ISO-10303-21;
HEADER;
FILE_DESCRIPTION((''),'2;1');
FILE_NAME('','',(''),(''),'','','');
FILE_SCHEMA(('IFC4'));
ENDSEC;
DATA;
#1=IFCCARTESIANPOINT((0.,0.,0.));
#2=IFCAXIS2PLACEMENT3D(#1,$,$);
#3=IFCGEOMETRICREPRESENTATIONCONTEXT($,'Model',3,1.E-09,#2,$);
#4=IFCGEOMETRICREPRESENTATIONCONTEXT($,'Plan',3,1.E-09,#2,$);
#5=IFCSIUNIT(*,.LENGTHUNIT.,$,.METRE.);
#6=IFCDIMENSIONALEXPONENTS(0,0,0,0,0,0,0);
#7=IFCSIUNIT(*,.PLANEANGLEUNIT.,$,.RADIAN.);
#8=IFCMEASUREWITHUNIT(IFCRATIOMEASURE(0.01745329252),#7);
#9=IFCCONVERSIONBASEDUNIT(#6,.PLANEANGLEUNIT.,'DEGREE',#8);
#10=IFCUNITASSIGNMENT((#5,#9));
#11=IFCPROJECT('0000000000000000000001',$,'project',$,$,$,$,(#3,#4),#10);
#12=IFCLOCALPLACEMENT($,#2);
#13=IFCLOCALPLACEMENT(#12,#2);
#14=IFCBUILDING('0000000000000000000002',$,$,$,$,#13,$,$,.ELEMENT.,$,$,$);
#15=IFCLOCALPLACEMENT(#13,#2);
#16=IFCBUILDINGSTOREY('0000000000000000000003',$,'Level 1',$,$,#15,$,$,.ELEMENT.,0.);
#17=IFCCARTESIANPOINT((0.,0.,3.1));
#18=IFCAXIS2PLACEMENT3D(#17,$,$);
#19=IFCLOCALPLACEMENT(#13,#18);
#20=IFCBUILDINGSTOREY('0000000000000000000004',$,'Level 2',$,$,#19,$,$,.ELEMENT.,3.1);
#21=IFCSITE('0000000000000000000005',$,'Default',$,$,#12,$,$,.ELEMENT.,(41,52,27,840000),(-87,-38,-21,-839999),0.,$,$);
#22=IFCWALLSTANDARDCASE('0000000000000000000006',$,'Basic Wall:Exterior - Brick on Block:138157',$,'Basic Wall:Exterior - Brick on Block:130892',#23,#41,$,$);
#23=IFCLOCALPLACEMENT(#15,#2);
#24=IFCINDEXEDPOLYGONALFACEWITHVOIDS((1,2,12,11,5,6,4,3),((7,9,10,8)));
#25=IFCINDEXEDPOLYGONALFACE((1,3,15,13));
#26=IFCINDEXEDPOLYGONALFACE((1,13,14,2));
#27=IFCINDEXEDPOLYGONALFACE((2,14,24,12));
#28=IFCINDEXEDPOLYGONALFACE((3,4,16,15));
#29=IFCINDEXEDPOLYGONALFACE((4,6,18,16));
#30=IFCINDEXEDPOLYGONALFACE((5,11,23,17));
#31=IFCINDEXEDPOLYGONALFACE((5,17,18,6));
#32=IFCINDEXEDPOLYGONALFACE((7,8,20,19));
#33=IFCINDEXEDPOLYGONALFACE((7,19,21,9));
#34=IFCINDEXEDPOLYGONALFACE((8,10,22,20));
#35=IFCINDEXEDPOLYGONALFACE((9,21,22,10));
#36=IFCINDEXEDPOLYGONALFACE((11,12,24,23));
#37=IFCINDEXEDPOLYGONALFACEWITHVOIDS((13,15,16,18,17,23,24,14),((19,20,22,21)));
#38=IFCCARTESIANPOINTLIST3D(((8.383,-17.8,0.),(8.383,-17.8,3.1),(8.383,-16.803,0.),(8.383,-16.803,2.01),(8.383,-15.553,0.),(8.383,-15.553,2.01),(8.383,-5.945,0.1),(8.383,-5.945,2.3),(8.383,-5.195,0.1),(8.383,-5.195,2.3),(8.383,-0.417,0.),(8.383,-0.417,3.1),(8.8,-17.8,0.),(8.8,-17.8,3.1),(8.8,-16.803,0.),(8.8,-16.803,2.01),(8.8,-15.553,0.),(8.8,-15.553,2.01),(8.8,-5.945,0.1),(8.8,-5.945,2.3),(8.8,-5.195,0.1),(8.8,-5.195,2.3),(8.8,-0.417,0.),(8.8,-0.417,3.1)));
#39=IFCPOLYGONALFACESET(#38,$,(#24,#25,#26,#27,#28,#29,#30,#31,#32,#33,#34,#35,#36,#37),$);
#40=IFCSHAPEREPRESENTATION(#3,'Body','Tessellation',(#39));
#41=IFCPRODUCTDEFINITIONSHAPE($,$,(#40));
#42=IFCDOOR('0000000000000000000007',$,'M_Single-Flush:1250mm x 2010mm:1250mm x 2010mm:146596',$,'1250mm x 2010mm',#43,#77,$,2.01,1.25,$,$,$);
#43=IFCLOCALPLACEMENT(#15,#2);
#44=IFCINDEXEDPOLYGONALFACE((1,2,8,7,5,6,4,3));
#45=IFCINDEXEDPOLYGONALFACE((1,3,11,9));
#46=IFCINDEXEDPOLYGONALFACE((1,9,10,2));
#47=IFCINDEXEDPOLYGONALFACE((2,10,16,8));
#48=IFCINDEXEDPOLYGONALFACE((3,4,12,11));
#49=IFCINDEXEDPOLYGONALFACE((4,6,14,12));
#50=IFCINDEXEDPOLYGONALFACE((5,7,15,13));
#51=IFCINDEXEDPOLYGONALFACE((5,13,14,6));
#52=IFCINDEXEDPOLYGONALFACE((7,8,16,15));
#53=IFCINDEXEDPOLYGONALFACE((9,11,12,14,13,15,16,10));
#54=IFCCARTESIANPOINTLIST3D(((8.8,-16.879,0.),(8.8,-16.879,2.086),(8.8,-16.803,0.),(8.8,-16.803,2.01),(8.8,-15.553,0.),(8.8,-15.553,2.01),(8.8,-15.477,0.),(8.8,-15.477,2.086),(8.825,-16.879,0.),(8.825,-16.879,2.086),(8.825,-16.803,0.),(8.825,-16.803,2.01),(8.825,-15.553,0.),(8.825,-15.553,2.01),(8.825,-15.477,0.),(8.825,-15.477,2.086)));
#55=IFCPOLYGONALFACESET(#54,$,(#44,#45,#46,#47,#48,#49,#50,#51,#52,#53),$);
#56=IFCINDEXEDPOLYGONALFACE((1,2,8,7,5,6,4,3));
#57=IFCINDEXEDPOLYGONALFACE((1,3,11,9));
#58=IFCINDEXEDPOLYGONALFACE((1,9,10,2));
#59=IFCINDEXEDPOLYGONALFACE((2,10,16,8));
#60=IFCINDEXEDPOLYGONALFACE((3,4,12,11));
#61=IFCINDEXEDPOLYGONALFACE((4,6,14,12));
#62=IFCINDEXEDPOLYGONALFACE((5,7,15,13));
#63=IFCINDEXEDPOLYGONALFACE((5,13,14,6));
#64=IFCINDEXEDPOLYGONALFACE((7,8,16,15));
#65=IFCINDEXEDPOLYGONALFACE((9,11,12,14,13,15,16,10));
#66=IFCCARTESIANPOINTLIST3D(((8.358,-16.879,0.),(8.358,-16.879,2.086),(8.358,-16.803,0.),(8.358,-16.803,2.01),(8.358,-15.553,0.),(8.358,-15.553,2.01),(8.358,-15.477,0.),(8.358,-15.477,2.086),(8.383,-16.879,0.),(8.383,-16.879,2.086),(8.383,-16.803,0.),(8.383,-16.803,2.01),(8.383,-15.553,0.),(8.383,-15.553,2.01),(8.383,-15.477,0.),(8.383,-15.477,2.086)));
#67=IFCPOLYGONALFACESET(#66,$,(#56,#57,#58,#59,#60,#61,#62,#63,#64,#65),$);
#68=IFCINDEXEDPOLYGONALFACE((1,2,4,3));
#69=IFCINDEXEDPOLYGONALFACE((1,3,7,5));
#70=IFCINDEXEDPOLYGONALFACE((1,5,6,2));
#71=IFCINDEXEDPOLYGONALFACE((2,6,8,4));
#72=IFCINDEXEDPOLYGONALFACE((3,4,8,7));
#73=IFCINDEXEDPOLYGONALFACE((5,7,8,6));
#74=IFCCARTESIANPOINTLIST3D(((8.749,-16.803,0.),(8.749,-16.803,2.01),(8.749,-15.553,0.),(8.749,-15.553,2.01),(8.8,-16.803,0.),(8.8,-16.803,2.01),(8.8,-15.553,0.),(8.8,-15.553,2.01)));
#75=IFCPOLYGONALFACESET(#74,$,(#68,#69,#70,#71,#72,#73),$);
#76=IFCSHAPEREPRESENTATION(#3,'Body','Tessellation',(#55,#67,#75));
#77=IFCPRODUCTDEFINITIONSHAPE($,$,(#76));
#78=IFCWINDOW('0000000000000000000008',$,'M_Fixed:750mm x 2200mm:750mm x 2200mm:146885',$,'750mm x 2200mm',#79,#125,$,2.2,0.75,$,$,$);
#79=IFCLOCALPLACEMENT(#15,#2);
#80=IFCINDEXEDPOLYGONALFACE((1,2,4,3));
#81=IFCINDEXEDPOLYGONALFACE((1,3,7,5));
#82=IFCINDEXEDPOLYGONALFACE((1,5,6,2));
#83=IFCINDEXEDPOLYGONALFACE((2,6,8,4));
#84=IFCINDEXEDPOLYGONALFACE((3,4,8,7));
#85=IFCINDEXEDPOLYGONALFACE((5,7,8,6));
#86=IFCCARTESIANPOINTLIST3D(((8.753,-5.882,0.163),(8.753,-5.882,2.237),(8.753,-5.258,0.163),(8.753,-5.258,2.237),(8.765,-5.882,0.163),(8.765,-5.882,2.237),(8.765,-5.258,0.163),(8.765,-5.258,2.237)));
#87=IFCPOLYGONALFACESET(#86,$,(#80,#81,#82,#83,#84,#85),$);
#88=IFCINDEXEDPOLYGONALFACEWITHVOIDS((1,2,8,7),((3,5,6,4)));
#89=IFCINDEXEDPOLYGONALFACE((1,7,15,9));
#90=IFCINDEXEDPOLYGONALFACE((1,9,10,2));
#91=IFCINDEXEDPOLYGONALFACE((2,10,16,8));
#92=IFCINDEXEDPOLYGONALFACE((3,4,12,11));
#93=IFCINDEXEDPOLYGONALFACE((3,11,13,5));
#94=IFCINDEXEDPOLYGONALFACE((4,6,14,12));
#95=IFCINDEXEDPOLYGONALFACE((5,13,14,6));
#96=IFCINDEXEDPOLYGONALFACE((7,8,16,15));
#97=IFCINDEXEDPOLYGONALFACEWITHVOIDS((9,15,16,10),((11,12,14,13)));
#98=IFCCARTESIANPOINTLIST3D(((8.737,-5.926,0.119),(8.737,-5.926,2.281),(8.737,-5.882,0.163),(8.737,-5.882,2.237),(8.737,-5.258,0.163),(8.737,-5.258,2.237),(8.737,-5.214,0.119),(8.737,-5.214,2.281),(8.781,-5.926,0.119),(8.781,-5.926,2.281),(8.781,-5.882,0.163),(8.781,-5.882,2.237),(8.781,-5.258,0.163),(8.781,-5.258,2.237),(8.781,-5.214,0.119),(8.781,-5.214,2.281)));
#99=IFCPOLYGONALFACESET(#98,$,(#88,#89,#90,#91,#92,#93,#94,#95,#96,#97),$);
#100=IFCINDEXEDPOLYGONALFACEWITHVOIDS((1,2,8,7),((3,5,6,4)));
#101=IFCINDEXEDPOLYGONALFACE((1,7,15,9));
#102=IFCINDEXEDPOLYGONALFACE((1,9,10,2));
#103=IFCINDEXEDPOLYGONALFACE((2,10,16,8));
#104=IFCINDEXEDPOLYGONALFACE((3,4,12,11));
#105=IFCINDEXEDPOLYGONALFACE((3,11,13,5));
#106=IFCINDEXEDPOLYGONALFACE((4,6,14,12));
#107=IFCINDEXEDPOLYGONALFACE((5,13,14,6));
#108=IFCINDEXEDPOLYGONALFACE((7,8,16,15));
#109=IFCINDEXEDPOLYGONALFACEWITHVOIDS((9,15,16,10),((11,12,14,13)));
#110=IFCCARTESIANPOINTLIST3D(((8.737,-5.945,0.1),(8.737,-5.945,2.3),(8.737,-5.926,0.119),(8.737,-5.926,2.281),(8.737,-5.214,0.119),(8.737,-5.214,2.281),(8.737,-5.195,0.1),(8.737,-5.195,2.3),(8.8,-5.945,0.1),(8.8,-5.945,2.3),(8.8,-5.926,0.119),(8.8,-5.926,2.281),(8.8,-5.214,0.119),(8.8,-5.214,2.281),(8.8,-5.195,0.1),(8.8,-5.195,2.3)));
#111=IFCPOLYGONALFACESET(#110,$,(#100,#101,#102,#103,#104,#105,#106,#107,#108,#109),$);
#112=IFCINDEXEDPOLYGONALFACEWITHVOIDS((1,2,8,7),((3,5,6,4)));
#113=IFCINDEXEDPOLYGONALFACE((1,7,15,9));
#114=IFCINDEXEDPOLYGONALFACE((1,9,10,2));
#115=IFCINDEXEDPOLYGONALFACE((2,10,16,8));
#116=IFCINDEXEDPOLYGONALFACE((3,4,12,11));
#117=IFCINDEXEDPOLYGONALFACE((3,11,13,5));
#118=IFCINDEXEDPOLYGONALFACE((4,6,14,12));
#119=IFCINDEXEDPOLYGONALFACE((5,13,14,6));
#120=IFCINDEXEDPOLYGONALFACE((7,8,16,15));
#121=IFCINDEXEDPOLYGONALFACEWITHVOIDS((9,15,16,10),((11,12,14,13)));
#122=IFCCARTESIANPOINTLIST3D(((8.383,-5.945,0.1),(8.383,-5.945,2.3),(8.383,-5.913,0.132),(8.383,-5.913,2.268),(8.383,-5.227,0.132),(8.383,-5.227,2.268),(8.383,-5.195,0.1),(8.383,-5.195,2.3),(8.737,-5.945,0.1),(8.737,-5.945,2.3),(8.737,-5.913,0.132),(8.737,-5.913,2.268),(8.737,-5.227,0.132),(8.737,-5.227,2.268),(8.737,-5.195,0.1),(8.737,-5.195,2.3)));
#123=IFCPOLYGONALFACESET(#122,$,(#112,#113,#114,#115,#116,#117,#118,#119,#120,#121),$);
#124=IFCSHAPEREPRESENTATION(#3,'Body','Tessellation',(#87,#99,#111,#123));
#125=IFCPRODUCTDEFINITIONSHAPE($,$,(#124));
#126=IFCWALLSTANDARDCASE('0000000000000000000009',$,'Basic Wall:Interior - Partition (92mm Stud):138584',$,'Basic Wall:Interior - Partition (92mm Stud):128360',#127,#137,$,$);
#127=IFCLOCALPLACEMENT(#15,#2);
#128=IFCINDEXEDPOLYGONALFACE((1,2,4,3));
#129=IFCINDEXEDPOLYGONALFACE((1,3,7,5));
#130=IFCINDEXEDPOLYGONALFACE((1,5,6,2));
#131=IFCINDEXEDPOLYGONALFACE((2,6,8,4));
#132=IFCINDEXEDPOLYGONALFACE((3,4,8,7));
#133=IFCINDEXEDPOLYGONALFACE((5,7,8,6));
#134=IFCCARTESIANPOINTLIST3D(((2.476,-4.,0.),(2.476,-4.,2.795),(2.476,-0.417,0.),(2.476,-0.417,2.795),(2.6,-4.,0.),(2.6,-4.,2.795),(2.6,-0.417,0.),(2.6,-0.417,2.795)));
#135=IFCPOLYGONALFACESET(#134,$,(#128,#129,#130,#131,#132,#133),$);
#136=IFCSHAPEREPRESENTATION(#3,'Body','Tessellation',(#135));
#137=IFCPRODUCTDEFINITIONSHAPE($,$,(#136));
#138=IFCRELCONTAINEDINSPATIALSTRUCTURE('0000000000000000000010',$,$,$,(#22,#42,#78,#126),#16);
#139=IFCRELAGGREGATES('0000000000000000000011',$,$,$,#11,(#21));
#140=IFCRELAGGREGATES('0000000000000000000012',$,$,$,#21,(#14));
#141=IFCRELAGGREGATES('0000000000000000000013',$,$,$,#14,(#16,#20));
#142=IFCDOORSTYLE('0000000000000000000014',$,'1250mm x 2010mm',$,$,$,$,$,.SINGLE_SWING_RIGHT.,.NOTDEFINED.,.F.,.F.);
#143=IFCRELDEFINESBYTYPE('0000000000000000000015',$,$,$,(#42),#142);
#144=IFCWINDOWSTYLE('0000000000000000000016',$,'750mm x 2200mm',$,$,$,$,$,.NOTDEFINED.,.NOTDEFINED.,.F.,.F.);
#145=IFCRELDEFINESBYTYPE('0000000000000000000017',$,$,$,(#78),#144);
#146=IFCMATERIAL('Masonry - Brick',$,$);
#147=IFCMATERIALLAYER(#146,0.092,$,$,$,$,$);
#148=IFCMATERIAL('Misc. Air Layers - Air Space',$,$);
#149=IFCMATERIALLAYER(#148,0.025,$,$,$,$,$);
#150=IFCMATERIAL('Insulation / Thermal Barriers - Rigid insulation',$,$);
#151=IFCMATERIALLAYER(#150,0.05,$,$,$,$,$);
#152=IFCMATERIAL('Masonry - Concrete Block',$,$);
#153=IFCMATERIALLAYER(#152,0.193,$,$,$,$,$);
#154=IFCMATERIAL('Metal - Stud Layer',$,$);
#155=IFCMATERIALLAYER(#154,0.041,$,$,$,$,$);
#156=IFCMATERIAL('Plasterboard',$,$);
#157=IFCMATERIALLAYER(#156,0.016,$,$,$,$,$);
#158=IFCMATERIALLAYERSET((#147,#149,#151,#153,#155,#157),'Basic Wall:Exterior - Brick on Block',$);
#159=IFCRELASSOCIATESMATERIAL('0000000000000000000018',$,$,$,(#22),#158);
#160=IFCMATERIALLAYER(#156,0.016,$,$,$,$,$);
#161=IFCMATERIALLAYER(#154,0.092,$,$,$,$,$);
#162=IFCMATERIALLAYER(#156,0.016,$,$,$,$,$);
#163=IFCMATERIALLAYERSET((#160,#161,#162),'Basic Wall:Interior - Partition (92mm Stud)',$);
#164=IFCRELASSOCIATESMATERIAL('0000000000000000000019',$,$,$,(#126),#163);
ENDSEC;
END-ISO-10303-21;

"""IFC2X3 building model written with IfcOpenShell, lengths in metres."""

from ifc_helpers import new_model, entity, si_unit, converted_unit, frame, frame_2d, origin, origin_2d_with_axis, place, context, project, spatial, polyline, rectangle, outline, extrude, source, transform, mapped, material, layer, layer_set, layer_usage, type_object, type_shapes, element, fill, save


model = new_model("IFC2X3")

# Units and contexts
model_context = context("Model", 3, precision=1e-09, world=origin())
plan_context = context("Plan", 3, precision=1e-09, world=origin())
ifc_project = project(units=[si_unit("LENGTHUNIT", "METRE"), converted_unit("PLANEANGLEUNIT", "DEGREE", entity("IfcRatioMeasure", 0.01745329252), si_unit("PLANEANGLEUNIT", "RADIAN"), dimensions=[0, 0, 0, 0, 0, 0, 0])], contexts=[model_context, plan_context])

# Site, building, storey
site_placement = place(None, origin())
site = spatial("IfcSite", under=ifc_project, at=site_placement, Name="Default", CompositionType="ELEMENT", RefLatitude=(41, 52, 27, 840000), RefLongitude=(-87, -38, -21, -839999), RefElevation=0.0)
building_placement = place(site_placement, origin())
building = spatial("IfcBuilding", under=site, at=building_placement, CompositionType="ELEMENT")
storey_1_placement = place(building_placement, origin())
storey_1 = spatial("IfcBuildingStorey", under=building, at=storey_1_placement, Name="Level 1", CompositionType="ELEMENT", Elevation=0.0)

# Shared definitions
ifc_material_1 = material(Name="Masonry - Brick")
ifc_layer_1 = layer(ifc_material_1, 0.092)
ifc_material_2 = material(Name="Misc. Air Layers - Air Space")
ifc_layer_2 = layer(ifc_material_2, 0.025)
ifc_material_3 = material(Name="Insulation / Thermal Barriers - Rigid insulation")
ifc_layer_3 = layer(ifc_material_3, 0.05)
ifc_material_4 = material(Name="Masonry - Concrete Block")
ifc_layer_4 = layer(ifc_material_4, 0.193)
ifc_material_5 = material(Name="Metal - Stud Layer")
ifc_layer_5 = layer(ifc_material_5, 0.041)
ifc_material_6 = material(Name="Plasterboard")
ifc_layer_6 = layer(ifc_material_6, 0.016)
ifc_layer_set_1 = layer_set([ifc_layer_1, ifc_layer_2, ifc_layer_3, ifc_layer_4, ifc_layer_5, ifc_layer_6], Name="Basic Wall:Exterior - Brick on Block")

# Wall, openings, door, window
ifc_layer_usage_1 = layer_usage(ifc_layer_set_1, "AXIS2", "NEGATIVE", 0.2085)
wall_1_placement = place(storey_1_placement, frame((8.5915, -0.417, 0.0), z_axis=(0.0, 0.0, 1.0), x_axis=(0.0, -1.0, 0.0)))
wall_1 = element("IfcWallStandardCase", 1, at=wall_1_placement, inside=storey_1, material=ifc_layer_usage_1, Name="Basic Wall:Exterior - Brick on Block:138157", ObjectType="Basic Wall:Exterior - Brick on Block:130892", context=model_context, shape_type="SweptSolid", body=[
    extrude(rectangle(XDim=17.383, YDim=0.417, at=frame_2d((8.6915, 0.0), x_axis=(-1.0, 0.0))), origin(), (0.0, 0.0, 1.0), 3.1),
])
opening_1_placement = place(wall_1_placement, frame((15.136, -0.2085, 0.0)))
opening_1 = element("IfcOpeningElement", 2, at=opening_1_placement, cuts=wall_1, ObjectType="Opening", context=model_context, shape_type="SweptSolid", body=[
    extrude(rectangle(XDim=1.25, YDim=2.01, at=frame_2d((1.005, 0.625), x_axis=(0.0, 1.0))), frame((0.0, 0.0, 0.0), z_axis=(0.0, 1.0, 0.0), x_axis=(0.0, 0.0, 1.0)), (0.0, 0.0, 1.0), 0.417),
])
opening_2_placement = place(wall_1_placement, frame((4.778, -0.2085, 0.1)))
opening_2 = element("IfcOpeningElement", 3, at=opening_2_placement, cuts=wall_1, ObjectType="Opening", context=model_context, shape_type="SweptSolid", body=[
    extrude(rectangle(XDim=2.2, YDim=0.75, at=frame_2d((1.1, 0.375), x_axis=(1.0, 0.0))), frame((0.0, 0.0, 0.0), z_axis=(0.0, 1.0, 0.0), x_axis=(0.0, 0.0, 1.0)), (0.0, 0.0, 1.0), 0.417),
])
door_style_1 = type_object("IfcDoorStyle", Name="1250mm x 2010mm", ConstructionType="NOTDEFINED", OperationType="SINGLE_SWING_RIGHT", ParameterTakesPrecedence=False, Sizeable=False)
shared_shape_1 = source(origin(), model_context, "Body", "SweptSolid", [
    extrude(outline(polyline([(-0.701, -1.062), (0.701, -1.062), (0.701, 1.024), (0.625, 1.024), (0.625, -0.986), (-0.625, -0.986), (-0.625, 1.024), (-0.701, 1.024), (-0.701, -1.062)])), frame((0.625, 0.417, 1.024), z_axis=(0.0, 1.0, 0.0), x_axis=(1.0, 0.0, 0.0)), (0.0, 0.0, 1.0), 0.025),
    extrude(outline(polyline([(-1.062, -0.701), (1.024, -0.701), (1.024, -0.625), (-0.986, -0.625), (-0.986, 0.625), (1.024, 0.625), (1.024, 0.701), (-1.062, 0.701), (-1.062, -0.701)])), frame((0.625, -0.025, 1.024), z_axis=(0.0, 1.0, 0.0), x_axis=(0.0, 0.0, -1.0)), (0.0, 0.0, 1.0), 0.025),
    extrude(rectangle(XDim=0.051, YDim=1.25, at=origin_2d_with_axis()), frame((0.625, 0.3915, 0.0), z_axis=(0.0, 0.0, 1.0), x_axis=(0.0, 1.0, 0.0)), (0.0, 0.0, 1.0), 2.01),
])
type_shapes(door_style_1, [shared_shape_1])
door_1_placement = place(opening_1_placement, origin())
door_1 = element("IfcDoor", 4, at=door_1_placement, inside=storey_1, type_object=door_style_1, Name="M_Single-Flush:1250mm x 2010mm:1250mm x 2010mm:146596", ObjectType="1250mm x 2010mm", OverallHeight=2.01, OverallWidth=1.25, context=model_context, shape_type="MappedRepresentation", body=[
    mapped(shared_shape_1, transform((0.0, 0.0, 0.0), scale=1.0)),
])
fill(opening_1, door_1)
window_style_1 = type_object("IfcWindowStyle", Name="750mm x 2200mm", ConstructionType="NOTDEFINED", OperationType="NOTDEFINED", ParameterTakesPrecedence=False, Sizeable=False)
shared_shape_2 = source(origin(), model_context, "Body", "SweptSolid", [
    extrude(rectangle(XDim=0.012, YDim=0.624, at=origin_2d_with_axis()), frame((0.375, 0.376, 0.063), z_axis=(0.0, 0.0, 1.0), x_axis=(0.0, -1.0, 0.0)), (0.0, 0.0, 1.0), 2.074),
    extrude(outline(polyline([(-0.356, -1.081), (0.356, -1.081), (0.356, 1.081), (-0.356, 1.081), (-0.356, -1.081)]), holes=[polyline([(-0.312, -1.037), (-0.312, 1.037), (0.312, 1.037), (0.312, -1.037), (-0.312, -1.037)])]), frame((0.375, 0.354, 1.1), z_axis=(0.0, 1.0, 0.0), x_axis=(1.0, 0.0, 0.0)), (0.0, 0.0, 1.0), 0.044),
    extrude(outline(polyline([(-0.375, -1.1), (0.375, -1.1), (0.375, 1.1), (-0.375, 1.1), (-0.375, -1.1)]), holes=[polyline([(-0.356, -1.081), (-0.356, 1.081), (0.356, 1.081), (0.356, -1.081), (-0.356, -1.081)])]), frame((0.375, 0.354, 1.1), z_axis=(0.0, 1.0, 0.0), x_axis=(1.0, 0.0, 0.0)), (0.0, 0.0, 1.0), 0.063),
    extrude(outline(polyline([(-0.375, -1.1), (0.375, -1.1), (0.375, 1.1), (-0.375, 1.1), (-0.375, -1.1)]), holes=[polyline([(-0.343, -1.068), (-0.343, 1.068), (0.343, 1.068), (0.343, -1.068), (-0.343, -1.068)])]), frame((0.375, 0.0, 1.1), z_axis=(0.0, 1.0, 0.0), x_axis=(1.0, 0.0, 0.0)), (0.0, 0.0, 1.0), 0.354),
])
type_shapes(window_style_1, [shared_shape_2])
window_1_placement = place(opening_2_placement, origin())
window_1 = element("IfcWindow", 5, at=window_1_placement, inside=storey_1, type_object=window_style_1, Name="M_Fixed:750mm x 2200mm:750mm x 2200mm:146885", ObjectType="750mm x 2200mm", OverallHeight=2.2, OverallWidth=0.75, context=model_context, shape_type="MappedRepresentation", body=[
    mapped(shared_shape_2, transform((0.0, 0.0, 0.0), scale=1.0)),
])
fill(opening_2, window_1)

# Wall
ifc_layer_7 = layer(ifc_material_6, 0.016)
ifc_layer_8 = layer(ifc_material_5, 0.092)
ifc_layer_9 = layer(ifc_material_6, 0.016)
ifc_layer_set_2 = layer_set([ifc_layer_7, ifc_layer_8, ifc_layer_9], Name="Basic Wall:Interior - Partition (92mm Stud)")
ifc_layer_usage_2 = layer_usage(ifc_layer_set_2, "AXIS2", "NEGATIVE", 0.062)
wall_2_placement = place(storey_1_placement, frame((2.538, -0.417, 0.0), z_axis=(0.0, 0.0, 1.0), x_axis=(0.0, -1.0, 0.0)))
element("IfcWallStandardCase", 6, at=wall_2_placement, inside=storey_1, material=ifc_layer_usage_2, Name="Basic Wall:Interior - Partition (92mm Stud):138584", ObjectType="Basic Wall:Interior - Partition (92mm Stud):128360", context=model_context, shape_type="SweptSolid", body=[
    extrude(rectangle(XDim=3.583, YDim=0.124, at=frame_2d((1.7915, 0.0), x_axis=(-1.0, 0.0))), origin(), (0.0, 0.0, 1.0), 2.795),
])

# Shared definitions
storey_2_placement = place(building_placement, frame((0.0, 0.0, 3.1)))
storey_2 = spatial("IfcBuildingStorey", under=building, at=storey_2_placement, Name="Level 2", CompositionType="ELEMENT", Elevation=3.1)

save(model, "model.ifc")
